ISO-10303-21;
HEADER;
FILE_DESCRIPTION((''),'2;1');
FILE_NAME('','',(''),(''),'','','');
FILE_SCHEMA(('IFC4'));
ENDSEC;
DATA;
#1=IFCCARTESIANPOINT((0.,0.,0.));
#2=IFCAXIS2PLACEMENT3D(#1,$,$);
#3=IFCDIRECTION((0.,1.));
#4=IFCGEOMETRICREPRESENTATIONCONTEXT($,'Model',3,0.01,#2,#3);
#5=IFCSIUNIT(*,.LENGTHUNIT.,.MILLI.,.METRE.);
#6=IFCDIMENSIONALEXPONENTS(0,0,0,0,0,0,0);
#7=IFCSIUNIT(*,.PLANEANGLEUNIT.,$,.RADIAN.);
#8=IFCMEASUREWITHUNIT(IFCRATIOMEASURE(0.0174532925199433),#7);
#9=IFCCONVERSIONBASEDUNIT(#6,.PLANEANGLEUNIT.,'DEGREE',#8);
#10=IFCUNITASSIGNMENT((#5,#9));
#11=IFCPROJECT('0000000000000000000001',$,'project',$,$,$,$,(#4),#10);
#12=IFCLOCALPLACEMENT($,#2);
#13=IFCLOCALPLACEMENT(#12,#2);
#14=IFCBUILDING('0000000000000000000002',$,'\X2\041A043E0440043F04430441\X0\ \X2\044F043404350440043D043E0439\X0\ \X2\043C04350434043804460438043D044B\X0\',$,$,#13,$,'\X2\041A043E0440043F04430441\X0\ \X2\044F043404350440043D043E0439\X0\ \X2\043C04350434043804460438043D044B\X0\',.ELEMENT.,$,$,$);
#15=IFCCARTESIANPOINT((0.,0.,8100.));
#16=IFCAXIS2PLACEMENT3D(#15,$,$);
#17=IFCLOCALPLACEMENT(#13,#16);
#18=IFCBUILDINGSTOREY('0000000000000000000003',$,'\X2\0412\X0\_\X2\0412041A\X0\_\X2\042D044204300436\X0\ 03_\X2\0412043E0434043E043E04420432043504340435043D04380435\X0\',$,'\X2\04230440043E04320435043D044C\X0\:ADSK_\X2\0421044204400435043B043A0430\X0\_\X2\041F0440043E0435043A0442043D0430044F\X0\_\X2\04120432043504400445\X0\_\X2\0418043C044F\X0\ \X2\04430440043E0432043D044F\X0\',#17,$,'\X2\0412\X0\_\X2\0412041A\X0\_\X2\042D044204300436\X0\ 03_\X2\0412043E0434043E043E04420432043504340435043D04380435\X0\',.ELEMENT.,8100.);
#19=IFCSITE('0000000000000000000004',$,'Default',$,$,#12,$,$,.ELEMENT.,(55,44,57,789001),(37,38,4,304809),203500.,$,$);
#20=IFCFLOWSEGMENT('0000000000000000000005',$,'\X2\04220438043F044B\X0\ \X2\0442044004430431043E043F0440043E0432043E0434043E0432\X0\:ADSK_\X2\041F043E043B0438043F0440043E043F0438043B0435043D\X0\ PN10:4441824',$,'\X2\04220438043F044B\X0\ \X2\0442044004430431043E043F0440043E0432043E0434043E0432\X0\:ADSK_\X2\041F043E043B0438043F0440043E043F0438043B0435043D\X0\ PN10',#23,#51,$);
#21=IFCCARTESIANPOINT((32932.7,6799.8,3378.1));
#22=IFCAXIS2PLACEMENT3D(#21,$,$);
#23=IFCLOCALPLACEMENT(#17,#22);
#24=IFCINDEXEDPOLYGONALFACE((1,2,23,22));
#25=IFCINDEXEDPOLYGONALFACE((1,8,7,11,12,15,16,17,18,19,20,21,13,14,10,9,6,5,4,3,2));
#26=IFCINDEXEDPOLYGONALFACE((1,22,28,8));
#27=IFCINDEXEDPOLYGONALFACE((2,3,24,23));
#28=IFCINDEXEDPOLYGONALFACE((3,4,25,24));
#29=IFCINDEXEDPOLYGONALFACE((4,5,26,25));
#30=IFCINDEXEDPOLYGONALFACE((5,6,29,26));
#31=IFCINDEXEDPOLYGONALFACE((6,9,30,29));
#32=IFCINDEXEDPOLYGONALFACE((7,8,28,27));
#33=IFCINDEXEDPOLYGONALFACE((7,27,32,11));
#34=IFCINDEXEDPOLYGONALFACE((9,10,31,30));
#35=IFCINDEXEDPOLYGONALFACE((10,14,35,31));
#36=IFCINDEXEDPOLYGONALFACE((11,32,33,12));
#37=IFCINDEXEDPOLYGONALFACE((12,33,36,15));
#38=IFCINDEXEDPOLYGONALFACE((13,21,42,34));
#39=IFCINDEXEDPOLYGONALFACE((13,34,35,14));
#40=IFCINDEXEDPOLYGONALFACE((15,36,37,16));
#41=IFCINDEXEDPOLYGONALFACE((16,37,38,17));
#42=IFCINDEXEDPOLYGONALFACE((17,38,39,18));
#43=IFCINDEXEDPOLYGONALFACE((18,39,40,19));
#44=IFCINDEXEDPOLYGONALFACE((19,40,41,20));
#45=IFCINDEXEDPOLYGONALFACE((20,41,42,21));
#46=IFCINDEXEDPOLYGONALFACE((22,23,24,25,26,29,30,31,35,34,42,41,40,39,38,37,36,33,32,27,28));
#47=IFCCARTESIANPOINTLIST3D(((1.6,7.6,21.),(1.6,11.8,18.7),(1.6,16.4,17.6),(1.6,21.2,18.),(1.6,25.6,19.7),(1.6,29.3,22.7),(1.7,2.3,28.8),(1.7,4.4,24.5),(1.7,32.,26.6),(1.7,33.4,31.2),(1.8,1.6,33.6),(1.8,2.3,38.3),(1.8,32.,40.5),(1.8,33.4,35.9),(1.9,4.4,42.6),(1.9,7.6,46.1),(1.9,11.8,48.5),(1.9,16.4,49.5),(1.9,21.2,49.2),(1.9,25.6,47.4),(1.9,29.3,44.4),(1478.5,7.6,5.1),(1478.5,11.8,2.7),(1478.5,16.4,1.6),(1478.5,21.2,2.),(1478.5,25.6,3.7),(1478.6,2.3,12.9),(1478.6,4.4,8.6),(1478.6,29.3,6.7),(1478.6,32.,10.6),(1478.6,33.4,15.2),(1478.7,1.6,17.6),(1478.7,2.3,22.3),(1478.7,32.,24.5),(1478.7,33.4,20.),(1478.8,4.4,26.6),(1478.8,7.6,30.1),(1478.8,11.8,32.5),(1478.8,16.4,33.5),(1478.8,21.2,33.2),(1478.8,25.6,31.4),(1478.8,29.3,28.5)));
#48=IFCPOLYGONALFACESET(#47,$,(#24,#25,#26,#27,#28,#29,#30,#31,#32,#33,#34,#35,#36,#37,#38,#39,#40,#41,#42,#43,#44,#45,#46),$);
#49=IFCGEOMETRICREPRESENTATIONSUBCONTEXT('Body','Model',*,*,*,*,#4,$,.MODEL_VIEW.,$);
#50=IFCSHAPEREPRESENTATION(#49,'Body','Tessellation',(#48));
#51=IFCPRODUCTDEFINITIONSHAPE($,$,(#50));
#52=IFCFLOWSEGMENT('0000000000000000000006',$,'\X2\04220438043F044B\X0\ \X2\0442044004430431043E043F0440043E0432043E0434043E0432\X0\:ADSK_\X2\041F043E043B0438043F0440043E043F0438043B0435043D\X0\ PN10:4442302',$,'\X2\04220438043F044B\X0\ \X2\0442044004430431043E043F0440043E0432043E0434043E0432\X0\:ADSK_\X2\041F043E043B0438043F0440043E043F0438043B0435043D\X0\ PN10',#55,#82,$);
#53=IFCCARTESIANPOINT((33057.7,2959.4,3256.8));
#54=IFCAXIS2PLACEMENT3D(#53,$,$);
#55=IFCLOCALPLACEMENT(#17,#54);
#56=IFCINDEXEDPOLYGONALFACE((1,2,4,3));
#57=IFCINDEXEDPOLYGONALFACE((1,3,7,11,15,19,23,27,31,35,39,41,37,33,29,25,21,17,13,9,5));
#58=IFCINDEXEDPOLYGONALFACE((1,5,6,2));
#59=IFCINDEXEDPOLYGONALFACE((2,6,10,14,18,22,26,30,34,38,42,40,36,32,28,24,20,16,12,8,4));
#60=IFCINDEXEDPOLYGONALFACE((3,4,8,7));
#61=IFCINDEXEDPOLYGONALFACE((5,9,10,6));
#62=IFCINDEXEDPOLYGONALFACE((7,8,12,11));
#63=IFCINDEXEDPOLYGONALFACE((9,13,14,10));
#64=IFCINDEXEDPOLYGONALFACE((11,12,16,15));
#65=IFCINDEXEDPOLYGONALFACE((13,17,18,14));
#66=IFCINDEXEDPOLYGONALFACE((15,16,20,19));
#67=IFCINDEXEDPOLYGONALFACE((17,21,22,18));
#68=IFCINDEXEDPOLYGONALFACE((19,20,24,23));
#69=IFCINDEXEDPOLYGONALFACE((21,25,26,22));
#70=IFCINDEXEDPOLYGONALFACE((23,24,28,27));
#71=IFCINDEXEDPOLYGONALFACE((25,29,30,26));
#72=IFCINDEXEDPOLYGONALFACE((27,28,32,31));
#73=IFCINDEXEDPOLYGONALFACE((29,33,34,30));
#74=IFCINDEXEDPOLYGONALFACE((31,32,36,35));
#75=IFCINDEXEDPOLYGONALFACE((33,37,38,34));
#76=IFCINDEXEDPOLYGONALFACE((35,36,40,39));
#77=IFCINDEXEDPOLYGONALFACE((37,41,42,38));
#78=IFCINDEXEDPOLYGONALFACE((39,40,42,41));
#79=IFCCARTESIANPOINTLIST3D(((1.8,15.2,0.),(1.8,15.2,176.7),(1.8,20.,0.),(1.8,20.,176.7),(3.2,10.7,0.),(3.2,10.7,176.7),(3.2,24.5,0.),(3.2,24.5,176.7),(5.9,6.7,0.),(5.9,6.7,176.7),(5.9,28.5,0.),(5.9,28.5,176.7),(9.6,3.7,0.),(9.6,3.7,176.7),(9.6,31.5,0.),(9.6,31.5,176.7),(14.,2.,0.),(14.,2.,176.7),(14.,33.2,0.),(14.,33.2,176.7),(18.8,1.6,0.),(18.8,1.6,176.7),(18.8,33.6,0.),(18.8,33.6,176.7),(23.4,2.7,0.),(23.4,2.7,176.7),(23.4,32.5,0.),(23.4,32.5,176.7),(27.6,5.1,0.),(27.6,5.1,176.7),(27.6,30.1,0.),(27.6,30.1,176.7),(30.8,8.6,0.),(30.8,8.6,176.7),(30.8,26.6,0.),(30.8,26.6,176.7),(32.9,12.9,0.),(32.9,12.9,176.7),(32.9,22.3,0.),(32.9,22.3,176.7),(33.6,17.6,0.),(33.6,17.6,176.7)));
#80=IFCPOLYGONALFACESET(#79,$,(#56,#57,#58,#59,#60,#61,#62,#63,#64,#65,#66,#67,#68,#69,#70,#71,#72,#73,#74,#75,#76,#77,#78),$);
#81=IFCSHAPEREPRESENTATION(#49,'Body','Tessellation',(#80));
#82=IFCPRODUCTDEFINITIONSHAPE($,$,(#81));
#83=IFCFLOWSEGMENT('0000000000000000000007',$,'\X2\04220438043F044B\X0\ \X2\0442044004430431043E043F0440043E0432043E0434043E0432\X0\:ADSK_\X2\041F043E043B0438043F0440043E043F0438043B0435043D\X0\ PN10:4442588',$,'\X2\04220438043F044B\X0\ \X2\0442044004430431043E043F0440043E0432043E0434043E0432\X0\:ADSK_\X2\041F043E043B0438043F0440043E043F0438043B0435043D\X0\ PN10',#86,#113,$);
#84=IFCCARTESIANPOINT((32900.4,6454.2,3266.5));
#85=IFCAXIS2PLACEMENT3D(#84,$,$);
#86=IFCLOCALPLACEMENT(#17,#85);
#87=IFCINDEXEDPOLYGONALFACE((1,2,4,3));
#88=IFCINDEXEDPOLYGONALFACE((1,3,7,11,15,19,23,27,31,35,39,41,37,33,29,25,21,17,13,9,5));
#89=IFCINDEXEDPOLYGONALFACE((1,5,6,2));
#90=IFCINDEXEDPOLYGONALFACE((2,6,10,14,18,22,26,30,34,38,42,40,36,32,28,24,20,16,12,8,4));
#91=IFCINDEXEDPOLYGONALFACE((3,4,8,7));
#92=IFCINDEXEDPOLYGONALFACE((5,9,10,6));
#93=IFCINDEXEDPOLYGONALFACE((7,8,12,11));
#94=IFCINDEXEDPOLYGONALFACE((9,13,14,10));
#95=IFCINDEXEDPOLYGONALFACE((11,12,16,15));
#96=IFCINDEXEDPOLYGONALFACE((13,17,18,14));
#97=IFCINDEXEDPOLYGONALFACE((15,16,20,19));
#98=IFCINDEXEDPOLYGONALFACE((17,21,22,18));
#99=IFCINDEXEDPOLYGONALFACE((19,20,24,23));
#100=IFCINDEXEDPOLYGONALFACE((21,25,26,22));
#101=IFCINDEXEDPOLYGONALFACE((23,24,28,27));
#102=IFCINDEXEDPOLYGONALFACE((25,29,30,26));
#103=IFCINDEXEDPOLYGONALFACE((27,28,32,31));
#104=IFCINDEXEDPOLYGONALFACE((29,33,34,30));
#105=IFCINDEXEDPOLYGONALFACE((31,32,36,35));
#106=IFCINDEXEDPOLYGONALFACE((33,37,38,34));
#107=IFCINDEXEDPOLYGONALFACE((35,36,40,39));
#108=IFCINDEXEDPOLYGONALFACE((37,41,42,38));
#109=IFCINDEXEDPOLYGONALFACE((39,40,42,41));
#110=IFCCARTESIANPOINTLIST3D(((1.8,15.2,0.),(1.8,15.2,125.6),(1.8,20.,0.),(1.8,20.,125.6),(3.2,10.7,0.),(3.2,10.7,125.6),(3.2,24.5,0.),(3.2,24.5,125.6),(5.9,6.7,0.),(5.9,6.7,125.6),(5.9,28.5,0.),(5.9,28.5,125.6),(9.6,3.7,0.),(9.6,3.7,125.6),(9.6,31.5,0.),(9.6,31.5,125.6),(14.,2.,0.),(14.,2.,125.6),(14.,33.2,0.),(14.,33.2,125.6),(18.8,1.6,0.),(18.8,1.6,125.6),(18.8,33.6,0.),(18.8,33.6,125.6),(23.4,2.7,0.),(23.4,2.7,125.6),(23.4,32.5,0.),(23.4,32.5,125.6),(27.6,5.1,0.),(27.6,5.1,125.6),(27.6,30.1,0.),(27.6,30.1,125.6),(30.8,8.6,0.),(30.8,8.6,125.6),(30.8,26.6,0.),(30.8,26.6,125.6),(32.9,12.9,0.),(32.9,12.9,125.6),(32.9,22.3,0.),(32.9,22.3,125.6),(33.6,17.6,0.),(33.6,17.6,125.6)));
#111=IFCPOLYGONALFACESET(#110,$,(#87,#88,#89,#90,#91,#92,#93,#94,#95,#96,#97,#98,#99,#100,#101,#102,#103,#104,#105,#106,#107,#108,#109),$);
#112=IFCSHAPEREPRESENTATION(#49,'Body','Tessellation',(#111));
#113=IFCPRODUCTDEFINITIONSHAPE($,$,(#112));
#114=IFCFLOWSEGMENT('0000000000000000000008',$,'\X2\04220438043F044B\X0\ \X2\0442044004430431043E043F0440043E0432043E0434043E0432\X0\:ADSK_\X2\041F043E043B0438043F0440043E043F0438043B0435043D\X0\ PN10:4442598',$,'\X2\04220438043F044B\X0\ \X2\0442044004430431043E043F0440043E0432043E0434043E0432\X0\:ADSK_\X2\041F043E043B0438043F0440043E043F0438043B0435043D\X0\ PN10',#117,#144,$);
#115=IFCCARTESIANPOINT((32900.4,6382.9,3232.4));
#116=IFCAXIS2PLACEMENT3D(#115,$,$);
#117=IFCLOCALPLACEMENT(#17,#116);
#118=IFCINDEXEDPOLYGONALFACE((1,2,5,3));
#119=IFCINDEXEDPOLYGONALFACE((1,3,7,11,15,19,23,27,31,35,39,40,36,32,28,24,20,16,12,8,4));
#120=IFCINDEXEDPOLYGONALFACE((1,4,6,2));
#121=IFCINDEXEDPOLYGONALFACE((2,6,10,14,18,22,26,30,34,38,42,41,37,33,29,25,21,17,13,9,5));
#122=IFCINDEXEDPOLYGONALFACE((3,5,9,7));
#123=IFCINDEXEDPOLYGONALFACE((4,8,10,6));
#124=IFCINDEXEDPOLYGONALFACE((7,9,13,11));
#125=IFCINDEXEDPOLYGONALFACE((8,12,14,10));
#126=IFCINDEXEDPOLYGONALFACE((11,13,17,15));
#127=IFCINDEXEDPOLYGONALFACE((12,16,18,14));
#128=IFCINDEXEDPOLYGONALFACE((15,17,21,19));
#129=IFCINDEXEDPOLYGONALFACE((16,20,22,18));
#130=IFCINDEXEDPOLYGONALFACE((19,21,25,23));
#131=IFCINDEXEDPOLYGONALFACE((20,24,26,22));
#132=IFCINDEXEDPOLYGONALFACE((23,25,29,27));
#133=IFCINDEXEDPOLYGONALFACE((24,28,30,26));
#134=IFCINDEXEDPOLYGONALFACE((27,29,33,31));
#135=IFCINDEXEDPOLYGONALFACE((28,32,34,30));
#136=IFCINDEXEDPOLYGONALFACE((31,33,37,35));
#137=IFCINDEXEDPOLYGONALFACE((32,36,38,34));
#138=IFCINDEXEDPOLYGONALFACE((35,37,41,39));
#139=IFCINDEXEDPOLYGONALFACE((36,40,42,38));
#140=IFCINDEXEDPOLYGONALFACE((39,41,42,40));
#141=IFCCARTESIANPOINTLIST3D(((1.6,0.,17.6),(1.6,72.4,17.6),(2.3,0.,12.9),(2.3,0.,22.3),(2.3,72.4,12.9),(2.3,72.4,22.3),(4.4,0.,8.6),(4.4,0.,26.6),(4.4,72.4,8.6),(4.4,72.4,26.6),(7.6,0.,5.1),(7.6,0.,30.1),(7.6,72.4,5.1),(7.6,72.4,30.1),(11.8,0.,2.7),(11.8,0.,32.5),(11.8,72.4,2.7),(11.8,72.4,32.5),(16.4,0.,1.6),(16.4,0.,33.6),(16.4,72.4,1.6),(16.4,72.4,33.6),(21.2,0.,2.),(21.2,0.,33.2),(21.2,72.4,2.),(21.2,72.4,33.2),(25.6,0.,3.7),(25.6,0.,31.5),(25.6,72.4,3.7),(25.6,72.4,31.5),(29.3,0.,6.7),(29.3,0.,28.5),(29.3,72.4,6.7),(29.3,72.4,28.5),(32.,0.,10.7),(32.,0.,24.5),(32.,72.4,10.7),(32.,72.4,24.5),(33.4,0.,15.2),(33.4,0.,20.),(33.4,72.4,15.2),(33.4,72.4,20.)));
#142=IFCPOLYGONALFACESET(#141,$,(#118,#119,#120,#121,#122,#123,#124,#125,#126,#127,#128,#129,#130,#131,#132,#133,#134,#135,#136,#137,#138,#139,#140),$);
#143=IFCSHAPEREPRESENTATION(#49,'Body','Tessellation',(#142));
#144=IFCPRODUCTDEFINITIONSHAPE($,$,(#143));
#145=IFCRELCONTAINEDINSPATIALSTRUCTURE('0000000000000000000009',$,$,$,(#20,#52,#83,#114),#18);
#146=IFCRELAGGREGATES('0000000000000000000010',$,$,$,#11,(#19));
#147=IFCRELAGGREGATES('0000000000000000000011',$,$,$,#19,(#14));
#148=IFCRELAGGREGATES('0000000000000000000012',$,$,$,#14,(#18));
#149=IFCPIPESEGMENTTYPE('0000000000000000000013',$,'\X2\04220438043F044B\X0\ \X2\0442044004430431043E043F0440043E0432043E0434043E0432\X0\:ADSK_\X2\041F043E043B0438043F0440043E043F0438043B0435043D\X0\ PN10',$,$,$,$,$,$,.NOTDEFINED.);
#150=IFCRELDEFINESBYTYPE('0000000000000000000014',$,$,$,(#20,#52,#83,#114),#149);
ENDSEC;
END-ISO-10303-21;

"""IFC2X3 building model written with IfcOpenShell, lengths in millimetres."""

from ifc_helpers import new_model, entity, si_unit, converted_unit, direction, frame, origin, origin_2d_with_axis, place, context, subcontext, project, spatial, circle, extrude, type_object, element, save


model = new_model("IFC2X3")

# Units and contexts
model_context = context("Model", 3, precision=0.01, world=origin(), true_north=direction((0.0, 1.0)))
body_context = subcontext(model_context, "Body", "Model", "MODEL_VIEW")
ifc_project = project(units=[si_unit("LENGTHUNIT", "METRE", prefix="MILLI"), converted_unit("PLANEANGLEUNIT", "DEGREE", entity("IfcRatioMeasure", 0.0174532925199433), si_unit("PLANEANGLEUNIT", "RADIAN"), dimensions=[0, 0, 0, 0, 0, 0, 0])], contexts=[model_context])

# Site, building, storey
site_placement = place(None, origin())
site = spatial("IfcSite", under=ifc_project, at=site_placement, Name="Default", CompositionType="ELEMENT", RefLatitude=(55, 44, 57, 789001), RefLongitude=(37, 38, 4, 304809), RefElevation=203500.0)
building_placement = place(site_placement, origin())
building = spatial("IfcBuilding", under=site, at=building_placement, Name="Корпус ядерной медицины", LongName="Корпус ядерной медицины", CompositionType="ELEMENT")
storey_placement = place(building_placement, frame((0.0, 0.0, 8100.0)))
storey = spatial("IfcBuildingStorey", under=building, at=storey_placement, Name="В_ВК_Этаж 03_Водоотведение", ObjectType="Уровень:ADSK_Стрелка_Проектная_Вверх_Имя уровня", LongName="В_ВК_Этаж 03_Водоотведение", CompositionType="ELEMENT", Elevation=8100.0)

# Flow segments
pipe_segment_type_1 = type_object("IfcPipeSegmentType", Name="Типы трубопроводов:ADSK_Полипропилен PN10", PredefinedType="NOTDEFINED")
flow_segment_1_placement = place(storey_placement, frame((32932.7, 6799.8, 3378.1)))
element("IfcFlowSegment", 1, at=flow_segment_1_placement, inside=storey, type_object=pipe_segment_type_1, Name="Типы трубопроводов:ADSK_Полипропилен PN10:4441824", ObjectType="Типы трубопроводов:ADSK_Полипропилен PN10", context=body_context, shape_type="SweptSolid", body=[
    extrude(circle(Radius=16.0, at=origin_2d_with_axis()), frame((1478.7, 17.6, 17.6), z_axis=(-0.999942, 0.0, 0.010811), x_axis=(0.0, -1.0, 0.0)), (0.0, 0.0, 1.0), 1477.0),
])
flow_segment_2_placement = place(storey_placement, frame((33057.7, 2959.4, 3256.8)))
element("IfcFlowSegment", 2, at=flow_segment_2_placement, inside=storey, type_object=pipe_segment_type_1, Name="Типы трубопроводов:ADSK_Полипропилен PN10:4442302", ObjectType="Типы трубопроводов:ADSK_Полипропилен PN10", context=body_context, shape_type="SweptSolid", body=[
    extrude(circle(Radius=16.0, at=origin_2d_with_axis()), frame((17.6, 17.6, 0.0)), (0.0, 0.0, 1.0), 176.7),
])
flow_segment_3_placement = place(storey_placement, frame((32900.4, 6454.2, 3266.5)))
element("IfcFlowSegment", 3, at=flow_segment_3_placement, inside=storey, type_object=pipe_segment_type_1, Name="Типы трубопроводов:ADSK_Полипропилен PN10:4442588", ObjectType="Типы трубопроводов:ADSK_Полипропилен PN10", context=body_context, shape_type="SweptSolid", body=[
    extrude(circle(Radius=16.0, at=origin_2d_with_axis()), frame((17.6, 17.6, 0.0)), (0.0, 0.0, 1.0), 125.6),
])
flow_segment_4_placement = place(storey_placement, frame((32900.4, 6382.9, 3232.4)))
element("IfcFlowSegment", 4, at=flow_segment_4_placement, inside=storey, type_object=pipe_segment_type_1, Name="Типы трубопроводов:ADSK_Полипропилен PN10:4442598", ObjectType="Типы трубопроводов:ADSK_Полипропилен PN10", context=body_context, shape_type="SweptSolid", body=[
    extrude(circle(Radius=16.0, at=origin_2d_with_axis()), frame((17.6, 0.0, 17.6), z_axis=(0.0, 1.0, 0.0), x_axis=(-1.0, 0.0, 0.0)), (0.0, 0.0, 1.0), 72.4),
])

save(model, "model.ifc")
